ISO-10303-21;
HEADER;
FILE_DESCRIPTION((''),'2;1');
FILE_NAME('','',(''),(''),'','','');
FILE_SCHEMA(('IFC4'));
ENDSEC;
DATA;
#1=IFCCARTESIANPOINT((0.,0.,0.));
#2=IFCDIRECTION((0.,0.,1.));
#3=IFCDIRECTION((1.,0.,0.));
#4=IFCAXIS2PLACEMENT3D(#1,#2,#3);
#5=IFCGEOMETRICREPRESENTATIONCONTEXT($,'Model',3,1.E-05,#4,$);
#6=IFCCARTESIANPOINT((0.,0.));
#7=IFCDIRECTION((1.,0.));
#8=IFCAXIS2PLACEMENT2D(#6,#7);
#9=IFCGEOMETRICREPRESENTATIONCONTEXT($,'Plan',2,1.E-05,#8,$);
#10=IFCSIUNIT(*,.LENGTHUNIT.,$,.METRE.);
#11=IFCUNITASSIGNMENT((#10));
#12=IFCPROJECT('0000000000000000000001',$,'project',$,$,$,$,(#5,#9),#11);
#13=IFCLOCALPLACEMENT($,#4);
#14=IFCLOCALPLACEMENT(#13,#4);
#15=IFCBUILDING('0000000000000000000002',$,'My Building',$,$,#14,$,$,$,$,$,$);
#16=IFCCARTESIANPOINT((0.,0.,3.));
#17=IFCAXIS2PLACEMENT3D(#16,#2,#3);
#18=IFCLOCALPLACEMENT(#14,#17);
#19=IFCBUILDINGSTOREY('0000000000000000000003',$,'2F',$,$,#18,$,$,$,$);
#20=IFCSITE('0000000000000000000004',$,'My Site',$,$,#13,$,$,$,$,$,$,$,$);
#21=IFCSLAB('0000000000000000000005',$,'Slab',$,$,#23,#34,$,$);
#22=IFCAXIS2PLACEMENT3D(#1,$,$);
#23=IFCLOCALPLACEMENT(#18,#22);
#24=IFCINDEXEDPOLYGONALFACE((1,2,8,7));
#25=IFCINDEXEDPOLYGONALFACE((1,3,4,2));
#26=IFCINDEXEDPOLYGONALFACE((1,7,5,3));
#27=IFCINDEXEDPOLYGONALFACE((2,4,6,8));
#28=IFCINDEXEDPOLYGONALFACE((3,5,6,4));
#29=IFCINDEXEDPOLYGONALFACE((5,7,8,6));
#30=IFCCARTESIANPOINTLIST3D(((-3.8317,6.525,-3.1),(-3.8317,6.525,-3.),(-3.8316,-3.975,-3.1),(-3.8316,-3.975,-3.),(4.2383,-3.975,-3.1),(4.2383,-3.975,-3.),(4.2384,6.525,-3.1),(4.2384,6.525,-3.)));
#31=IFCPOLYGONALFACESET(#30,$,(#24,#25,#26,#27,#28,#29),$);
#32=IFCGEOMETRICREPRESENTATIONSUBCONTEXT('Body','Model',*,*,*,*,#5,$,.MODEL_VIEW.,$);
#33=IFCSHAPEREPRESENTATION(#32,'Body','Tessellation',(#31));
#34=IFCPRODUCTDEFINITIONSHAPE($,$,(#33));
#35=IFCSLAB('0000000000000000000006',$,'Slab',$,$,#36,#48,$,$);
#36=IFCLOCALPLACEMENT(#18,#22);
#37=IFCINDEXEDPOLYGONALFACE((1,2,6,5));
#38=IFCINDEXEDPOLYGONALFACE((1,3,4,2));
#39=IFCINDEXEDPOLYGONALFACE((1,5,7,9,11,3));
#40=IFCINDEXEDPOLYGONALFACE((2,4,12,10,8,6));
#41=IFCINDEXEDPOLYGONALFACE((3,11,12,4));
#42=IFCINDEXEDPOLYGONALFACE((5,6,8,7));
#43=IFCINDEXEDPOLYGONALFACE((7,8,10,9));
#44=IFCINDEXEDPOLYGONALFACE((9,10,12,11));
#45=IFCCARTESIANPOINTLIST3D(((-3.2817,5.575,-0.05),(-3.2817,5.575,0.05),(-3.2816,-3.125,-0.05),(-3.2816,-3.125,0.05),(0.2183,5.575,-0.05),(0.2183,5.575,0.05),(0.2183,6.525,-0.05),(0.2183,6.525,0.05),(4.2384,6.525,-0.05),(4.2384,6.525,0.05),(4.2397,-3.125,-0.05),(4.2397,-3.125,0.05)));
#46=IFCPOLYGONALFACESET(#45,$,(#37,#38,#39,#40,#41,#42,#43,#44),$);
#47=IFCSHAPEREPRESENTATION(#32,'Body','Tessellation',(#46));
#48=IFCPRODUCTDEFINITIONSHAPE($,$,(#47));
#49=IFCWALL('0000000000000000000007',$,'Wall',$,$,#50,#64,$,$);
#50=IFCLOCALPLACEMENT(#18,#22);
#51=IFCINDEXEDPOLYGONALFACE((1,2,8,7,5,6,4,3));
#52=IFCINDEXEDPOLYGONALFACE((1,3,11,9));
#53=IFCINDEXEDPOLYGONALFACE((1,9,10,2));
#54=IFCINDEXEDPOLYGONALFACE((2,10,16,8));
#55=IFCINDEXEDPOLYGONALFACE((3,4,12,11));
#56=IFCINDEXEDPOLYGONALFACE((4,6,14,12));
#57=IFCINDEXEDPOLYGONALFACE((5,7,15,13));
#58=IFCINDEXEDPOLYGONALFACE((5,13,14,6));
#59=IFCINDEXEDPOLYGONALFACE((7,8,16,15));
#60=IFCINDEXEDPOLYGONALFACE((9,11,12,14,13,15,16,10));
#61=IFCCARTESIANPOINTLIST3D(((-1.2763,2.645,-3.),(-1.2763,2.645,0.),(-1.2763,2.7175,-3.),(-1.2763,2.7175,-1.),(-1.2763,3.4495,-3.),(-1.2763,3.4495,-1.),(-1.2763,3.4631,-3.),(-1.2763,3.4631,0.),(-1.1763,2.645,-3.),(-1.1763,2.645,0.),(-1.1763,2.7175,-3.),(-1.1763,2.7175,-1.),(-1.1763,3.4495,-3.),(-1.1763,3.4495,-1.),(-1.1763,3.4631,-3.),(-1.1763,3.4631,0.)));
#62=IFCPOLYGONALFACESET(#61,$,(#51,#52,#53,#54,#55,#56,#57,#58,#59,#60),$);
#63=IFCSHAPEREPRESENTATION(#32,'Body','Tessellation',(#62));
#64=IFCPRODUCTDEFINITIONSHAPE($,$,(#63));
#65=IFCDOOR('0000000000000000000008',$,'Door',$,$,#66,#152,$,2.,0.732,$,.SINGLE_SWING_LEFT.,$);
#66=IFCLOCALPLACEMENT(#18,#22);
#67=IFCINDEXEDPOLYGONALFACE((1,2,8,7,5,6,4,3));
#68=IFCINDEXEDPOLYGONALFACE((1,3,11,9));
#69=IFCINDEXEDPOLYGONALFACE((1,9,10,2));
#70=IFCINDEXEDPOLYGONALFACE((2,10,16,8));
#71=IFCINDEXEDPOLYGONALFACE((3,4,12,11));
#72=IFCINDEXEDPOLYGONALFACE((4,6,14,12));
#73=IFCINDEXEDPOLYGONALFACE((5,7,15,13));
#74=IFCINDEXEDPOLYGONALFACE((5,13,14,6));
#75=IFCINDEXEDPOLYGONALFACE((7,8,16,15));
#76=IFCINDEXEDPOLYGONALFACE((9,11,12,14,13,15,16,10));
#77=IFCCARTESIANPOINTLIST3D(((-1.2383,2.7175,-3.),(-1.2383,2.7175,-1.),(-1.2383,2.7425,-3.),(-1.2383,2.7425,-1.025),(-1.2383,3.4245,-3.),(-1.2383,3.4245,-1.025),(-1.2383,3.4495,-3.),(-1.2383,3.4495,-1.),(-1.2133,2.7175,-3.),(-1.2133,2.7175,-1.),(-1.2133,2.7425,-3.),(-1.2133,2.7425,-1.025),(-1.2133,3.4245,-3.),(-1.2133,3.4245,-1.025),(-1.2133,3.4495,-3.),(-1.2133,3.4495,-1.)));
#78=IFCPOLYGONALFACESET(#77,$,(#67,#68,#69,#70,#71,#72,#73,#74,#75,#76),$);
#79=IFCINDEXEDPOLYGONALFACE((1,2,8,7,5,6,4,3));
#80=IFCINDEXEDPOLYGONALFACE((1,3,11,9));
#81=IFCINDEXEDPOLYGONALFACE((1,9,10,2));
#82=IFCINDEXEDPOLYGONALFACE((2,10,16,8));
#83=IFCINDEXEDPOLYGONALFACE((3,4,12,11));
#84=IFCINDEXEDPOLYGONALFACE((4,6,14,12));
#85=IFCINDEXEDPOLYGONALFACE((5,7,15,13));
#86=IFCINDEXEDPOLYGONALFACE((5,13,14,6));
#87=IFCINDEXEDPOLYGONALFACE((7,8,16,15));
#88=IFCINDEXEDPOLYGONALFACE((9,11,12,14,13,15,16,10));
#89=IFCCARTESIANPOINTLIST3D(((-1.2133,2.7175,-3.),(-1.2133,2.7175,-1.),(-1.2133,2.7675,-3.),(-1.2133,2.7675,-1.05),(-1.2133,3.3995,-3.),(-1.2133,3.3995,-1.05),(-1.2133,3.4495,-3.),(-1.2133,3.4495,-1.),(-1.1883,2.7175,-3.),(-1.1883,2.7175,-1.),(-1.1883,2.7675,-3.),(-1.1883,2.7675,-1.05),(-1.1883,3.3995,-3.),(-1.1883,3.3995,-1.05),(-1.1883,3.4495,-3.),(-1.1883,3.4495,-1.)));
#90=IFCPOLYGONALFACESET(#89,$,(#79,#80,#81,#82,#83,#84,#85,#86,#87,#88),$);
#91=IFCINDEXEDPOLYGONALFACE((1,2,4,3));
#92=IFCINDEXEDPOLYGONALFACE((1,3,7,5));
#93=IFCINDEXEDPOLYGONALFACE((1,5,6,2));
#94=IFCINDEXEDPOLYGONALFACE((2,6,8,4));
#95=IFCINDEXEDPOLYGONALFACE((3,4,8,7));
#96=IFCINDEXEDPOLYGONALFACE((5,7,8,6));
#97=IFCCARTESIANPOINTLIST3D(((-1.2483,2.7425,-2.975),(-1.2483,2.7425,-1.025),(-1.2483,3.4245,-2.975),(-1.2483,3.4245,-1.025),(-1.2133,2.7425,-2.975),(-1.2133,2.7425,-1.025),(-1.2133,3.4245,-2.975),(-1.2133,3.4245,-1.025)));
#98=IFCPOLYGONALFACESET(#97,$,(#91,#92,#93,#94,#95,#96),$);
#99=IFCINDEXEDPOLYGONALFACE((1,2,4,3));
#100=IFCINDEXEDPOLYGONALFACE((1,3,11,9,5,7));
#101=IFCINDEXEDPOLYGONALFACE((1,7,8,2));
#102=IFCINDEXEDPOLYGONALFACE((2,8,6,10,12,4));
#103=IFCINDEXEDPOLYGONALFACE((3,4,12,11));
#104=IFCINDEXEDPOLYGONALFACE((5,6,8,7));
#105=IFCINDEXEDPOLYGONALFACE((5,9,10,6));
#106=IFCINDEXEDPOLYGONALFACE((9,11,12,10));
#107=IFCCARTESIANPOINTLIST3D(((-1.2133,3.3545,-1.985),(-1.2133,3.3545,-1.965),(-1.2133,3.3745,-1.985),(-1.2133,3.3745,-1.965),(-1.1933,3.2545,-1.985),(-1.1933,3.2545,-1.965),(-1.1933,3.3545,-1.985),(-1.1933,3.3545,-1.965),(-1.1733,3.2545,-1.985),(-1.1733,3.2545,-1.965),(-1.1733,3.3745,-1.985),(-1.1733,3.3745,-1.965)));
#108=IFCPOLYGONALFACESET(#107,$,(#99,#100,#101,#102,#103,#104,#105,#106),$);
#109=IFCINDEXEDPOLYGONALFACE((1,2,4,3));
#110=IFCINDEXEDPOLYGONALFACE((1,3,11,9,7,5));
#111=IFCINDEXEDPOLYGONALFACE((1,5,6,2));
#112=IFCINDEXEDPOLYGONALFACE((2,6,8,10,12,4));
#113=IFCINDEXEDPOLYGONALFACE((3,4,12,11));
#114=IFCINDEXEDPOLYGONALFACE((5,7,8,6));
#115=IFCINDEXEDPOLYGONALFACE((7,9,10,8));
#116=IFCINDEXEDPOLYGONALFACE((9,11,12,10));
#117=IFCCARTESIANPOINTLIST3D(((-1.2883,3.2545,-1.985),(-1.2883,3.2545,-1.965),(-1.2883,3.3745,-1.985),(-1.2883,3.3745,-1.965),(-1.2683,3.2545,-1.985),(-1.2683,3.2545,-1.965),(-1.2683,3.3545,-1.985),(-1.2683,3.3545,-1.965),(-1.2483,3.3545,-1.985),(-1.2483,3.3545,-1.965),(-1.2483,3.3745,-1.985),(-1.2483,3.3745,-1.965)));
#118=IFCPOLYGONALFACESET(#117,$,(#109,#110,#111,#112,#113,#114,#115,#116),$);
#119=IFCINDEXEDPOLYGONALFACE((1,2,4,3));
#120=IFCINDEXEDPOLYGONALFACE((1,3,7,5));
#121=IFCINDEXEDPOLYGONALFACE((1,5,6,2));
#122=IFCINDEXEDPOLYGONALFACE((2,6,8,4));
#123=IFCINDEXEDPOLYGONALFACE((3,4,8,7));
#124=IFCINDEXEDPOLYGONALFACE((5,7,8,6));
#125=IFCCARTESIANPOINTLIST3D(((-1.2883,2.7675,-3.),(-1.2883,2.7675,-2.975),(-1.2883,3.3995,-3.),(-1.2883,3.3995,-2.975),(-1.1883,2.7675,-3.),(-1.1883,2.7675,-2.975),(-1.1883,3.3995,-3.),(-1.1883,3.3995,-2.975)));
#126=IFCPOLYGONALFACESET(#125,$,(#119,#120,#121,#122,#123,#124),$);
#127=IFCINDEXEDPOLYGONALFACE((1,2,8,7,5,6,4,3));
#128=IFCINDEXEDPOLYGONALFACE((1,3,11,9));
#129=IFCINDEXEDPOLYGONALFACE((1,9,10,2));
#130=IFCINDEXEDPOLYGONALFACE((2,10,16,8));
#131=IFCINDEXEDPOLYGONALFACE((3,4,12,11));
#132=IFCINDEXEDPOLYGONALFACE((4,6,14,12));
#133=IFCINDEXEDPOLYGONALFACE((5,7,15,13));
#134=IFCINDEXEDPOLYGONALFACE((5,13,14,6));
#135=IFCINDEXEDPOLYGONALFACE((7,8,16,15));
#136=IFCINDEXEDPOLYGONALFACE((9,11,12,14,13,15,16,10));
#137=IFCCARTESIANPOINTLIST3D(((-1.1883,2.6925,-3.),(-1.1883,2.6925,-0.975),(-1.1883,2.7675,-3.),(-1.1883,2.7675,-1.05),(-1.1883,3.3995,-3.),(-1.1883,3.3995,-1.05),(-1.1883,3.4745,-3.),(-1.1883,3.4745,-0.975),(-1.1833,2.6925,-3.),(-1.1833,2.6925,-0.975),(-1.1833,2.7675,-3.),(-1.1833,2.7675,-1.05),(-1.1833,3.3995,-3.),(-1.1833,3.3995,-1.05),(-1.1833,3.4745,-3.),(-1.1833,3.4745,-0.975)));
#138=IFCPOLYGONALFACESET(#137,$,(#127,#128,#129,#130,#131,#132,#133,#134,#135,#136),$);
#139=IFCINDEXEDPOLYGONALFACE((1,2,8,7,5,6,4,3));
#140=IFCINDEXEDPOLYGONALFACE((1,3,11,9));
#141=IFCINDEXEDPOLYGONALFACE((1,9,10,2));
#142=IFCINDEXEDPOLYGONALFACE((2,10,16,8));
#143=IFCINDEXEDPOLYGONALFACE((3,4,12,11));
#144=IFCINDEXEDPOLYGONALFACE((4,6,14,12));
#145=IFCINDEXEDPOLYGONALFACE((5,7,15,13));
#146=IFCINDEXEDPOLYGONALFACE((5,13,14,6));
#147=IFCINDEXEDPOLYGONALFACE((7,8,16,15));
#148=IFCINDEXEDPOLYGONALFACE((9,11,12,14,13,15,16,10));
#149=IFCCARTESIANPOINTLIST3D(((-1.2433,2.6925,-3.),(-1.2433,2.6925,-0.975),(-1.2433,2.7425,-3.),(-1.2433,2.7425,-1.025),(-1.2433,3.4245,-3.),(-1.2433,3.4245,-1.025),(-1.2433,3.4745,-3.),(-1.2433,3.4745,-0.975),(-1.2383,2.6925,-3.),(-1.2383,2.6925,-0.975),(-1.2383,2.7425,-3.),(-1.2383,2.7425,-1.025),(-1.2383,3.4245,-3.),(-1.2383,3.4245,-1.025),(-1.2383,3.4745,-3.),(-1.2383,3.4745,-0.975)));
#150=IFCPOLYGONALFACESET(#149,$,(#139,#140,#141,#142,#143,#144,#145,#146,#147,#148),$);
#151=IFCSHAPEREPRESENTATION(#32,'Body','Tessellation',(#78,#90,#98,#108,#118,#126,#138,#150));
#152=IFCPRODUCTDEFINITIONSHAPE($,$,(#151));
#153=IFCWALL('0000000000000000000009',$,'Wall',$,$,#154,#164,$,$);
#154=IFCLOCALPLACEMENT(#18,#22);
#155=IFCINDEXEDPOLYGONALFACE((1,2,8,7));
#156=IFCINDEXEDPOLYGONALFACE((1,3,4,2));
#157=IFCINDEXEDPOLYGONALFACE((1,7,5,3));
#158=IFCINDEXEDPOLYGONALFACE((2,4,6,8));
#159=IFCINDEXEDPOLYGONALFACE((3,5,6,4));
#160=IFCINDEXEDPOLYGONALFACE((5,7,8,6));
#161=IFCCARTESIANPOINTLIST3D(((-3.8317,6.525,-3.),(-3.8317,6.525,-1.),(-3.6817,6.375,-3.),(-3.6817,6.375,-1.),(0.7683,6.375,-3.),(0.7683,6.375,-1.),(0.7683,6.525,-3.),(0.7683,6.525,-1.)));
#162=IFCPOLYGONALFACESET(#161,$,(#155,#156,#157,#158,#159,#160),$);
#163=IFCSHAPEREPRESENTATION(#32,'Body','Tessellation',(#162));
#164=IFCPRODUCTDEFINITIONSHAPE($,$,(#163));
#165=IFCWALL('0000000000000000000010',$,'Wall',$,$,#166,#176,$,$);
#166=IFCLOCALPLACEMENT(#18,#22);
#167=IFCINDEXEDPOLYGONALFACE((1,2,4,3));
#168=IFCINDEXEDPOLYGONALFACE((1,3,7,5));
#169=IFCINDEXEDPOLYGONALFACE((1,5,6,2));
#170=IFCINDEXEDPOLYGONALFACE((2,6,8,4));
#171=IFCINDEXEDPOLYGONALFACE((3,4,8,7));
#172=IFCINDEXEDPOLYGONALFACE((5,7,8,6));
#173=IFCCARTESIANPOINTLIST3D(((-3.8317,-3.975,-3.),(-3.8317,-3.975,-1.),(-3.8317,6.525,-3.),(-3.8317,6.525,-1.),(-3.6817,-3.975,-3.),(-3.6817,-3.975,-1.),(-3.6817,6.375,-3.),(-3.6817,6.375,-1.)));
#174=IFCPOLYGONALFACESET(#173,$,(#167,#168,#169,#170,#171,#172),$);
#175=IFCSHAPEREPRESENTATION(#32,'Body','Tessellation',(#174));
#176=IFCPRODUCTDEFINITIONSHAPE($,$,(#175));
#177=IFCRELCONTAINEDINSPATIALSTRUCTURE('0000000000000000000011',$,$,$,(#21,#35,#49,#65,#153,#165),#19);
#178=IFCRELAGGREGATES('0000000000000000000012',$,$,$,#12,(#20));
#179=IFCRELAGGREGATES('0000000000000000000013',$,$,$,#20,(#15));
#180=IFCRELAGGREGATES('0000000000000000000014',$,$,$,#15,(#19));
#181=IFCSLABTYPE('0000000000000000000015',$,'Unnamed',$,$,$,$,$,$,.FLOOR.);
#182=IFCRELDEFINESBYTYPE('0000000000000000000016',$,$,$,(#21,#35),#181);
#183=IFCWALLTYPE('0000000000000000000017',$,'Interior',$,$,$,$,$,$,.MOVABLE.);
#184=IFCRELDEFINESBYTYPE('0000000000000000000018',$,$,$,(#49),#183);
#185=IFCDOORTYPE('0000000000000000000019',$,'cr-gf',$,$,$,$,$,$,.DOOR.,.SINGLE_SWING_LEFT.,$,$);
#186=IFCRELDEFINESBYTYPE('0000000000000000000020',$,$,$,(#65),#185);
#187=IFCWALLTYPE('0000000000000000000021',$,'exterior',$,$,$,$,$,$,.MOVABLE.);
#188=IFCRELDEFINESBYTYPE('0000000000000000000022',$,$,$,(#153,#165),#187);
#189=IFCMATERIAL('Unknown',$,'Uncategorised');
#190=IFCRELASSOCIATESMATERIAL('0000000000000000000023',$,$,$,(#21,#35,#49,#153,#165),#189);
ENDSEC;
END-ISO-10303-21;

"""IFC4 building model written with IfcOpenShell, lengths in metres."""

from ifc_helpers import new_model, entity, si_unit, frame, origin_with_axes, origin_2d_with_axis, place, context, subcontext, project, spatial, line, indexed_curve, outline, extrude, shape, source, transform, mapped, material, type_object, type_shapes, element, fill, save


model = new_model("IFC4")

# Units and contexts
model_context = context("Model", 3, precision=1e-05, world=origin_with_axes())
plan_context = context("Plan", 2, precision=1e-05, world=origin_2d_with_axis())
body_context_1 = subcontext(model_context, "Body", "Model", "MODEL_VIEW")
body_context_2 = subcontext(plan_context, "Body", "Plan", "PLAN_VIEW")
ifc_project = project(units=[si_unit("LENGTHUNIT", "METRE")], contexts=[model_context, plan_context])

# Site, building, storey
site_placement = place(None, origin_with_axes())
site = spatial("IfcSite", under=ifc_project, at=site_placement, Name="My Site")
building_placement = place(site_placement, origin_with_axes())
building = spatial("IfcBuilding", under=site, at=building_placement, Name="My Building")
storey_placement = place(building_placement, frame((0.0, 0.0, 3.0), z_axis=(0.0, 0.0, 1.0), x_axis=(1.0, 0.0, 0.0)))
storey = spatial("IfcBuildingStorey", under=building, at=storey_placement, Name="2F")

# Slabs
ifc_material = material(Name="Unknown", Category="Uncategorised")
slab_type = type_object("IfcSlabType", Name="Unnamed", PredefinedType="FLOOR")
for number, where, z_axis, x_axis, name in (
    (1, (4.2384, 6.525, -3.0), (0.0, 0.0, 1.0), (1.0, 0.0, 0.0), "Slab"),
):
    element("IfcSlab", number, at=place(storey_placement, frame(where, z_axis=z_axis, x_axis=x_axis)), inside=storey, type_object=slab_type, material=ifc_material, Name=name, context=body_context_1, shape_type="SweptSolid", body=[
        extrude(outline(indexed_curve([(0.0, 0.0), (-8.07, 0.0), (-8.07, -10.5), (0.0, -10.5), (0.0, 0.0)])), frame((0.0, 0.0, -0.1), z_axis=(0.0, 0.0, 1.0), x_axis=(1.0, 0.0, 0.0)), (0.0, 0.0, 1.0), 0.1),
    ])
slab_placement = place(storey_placement, frame((4.2384, 6.525, 0.05), z_axis=(0.0, 0.0, 1.0), x_axis=(1.0, 0.0, 0.0)))
element("IfcSlab", 2, at=slab_placement, inside=storey, type_object=slab_type, material=ifc_material, Name="Slab", context=body_context_1, shape_type="SweptSolid", body=[
    extrude(outline(indexed_curve([(0.0, 0.0), (-4.02, 0.0), (-4.02, -0.95), (-7.52, -0.95), (-7.52, -9.65), (0.0014, -9.65), (0.0, 0.0)])), frame((0.0, 0.0, -0.1), z_axis=(0.0, 0.0, 1.0), x_axis=(1.0, 0.0, 0.0)), (0.0, 0.0, 1.0), 0.1),
])

# Wall, opening, door
wall_type_1 = type_object("IfcWallType", Name="Interior", PredefinedType="MOVABLE")
wall_1_placement = place(storey_placement, frame((-1.2763, 3.4631, -3.0), z_axis=(0.0, 0.0, 1.0), x_axis=(0.0, -1.0, 0.0)))
wall_1 = element("IfcWall", 3, at=wall_1_placement, inside=storey, type_object=wall_type_1, material=ifc_material, Name="Wall", context=body_context_1, shape_type="SweptSolid", body=[
    extrude(outline(indexed_curve([(0.0, 0.0), (0.0, 0.1), (0.8182, 0.1), (0.8182, 0.0)], segments=[line(1, 2, 3, 4, 1)])), origin_with_axes(), (0.0, 0.0, 1.0), 3.0),
])
shared_shape_1 = source(origin_with_axes(), body_context_1, "Body", "SweptSolid", [
    extrude(outline(indexed_curve([(0.0, 0.0), (0.732, 0.0), (0.732, 2.0), (0.0, 2.0)], segments=[line(1, 2, 3, 4, 1)])), frame((0.0, -0.6, 0.0), z_axis=(0.0, -1.0, 0.0), x_axis=(1.0, 0.0, 0.0)), (0.0, 0.0, -1.0), 1.2),
])
opening_1_placement = place(wall_1_placement, frame((0.7456, 0.088, 0.0), z_axis=(0.0, 0.0, 1.0), x_axis=(-1.0, 0.0, 0.0)))
opening_1 = element("IfcOpeningElement", 4, at=opening_1_placement, cuts=wall_1, PredefinedType="OPENING", context=body_context_1, shape_type="MappedRepresentation", body=[
    mapped(shared_shape_1, transform((0.0, 0.0, 0.0), x_axis=(1.0, 0.0, 0.0), y_axis=(0.0, 1.0, 0.0), z_axis=(0.0, 0.0, 1.0), scale=1.0)),
])
door_type_1 = type_object("IfcDoorType", Name="cr-gf", OperationType="SINGLE_SWING_LEFT", PredefinedType="DOOR")
shared_shape_2 = source(origin_with_axes(), body_context_1, "Body", "SweptSolid", [
    extrude(outline(indexed_curve([(0.0, 0.0), (0.0, 2.0), (0.732, 2.0), (0.732, 0.0), (0.707, 0.0), (0.707, 1.975), (0.025, 1.975), (0.025, 0.0)], segments=[line(1, 2, 3, 4, 5, 6, 7, 8, 1)])), frame((0.0, 0.025, 0.0), z_axis=(0.0, -1.0, 0.0), x_axis=(1.0, 0.0, 0.0)), (0.0, 0.0, -1.0), 0.025),
    extrude(outline(indexed_curve([(0.0, 0.0), (0.0, 2.0), (0.732, 2.0), (0.732, 0.0), (0.682, 0.0), (0.682, 1.95), (0.05, 1.95), (0.05, 0.0)], segments=[line(1, 2, 3, 4, 5, 6, 7, 8, 1)])), frame((0.0, 0.0, 0.0), z_axis=(0.0, -1.0, 0.0), x_axis=(1.0, 0.0, 0.0)), (0.0, 0.0, -1.0), 0.025),
    extrude(outline(indexed_curve([(0.0, 0.0), (0.682, 0.0), (0.682, 0.035), (0.0, 0.035)], segments=[line(1, 2, 3, 4, 1)])), frame((0.025, 0.025, 0.025), z_axis=(0.0, 0.0, 1.0), x_axis=(1.0, 0.0, 0.0)), (0.0, 0.0, 1.0), 1.95),
    extrude(outline(indexed_curve([(0.0, 0.0), (0.0, -0.04), (-0.12, -0.04), (-0.12, -0.02), (-0.02, -0.02), (-0.02, 0.0)], segments=[line(1, 2, 3, 4, 5, 6, 1)])), frame((0.657, 0.025, 1.015), z_axis=(0.0, 0.0, 1.0), x_axis=(1.0, 0.0, 0.0)), (0.0, 0.0, 1.0), 0.02),
    extrude(outline(indexed_curve([(0.0, 0.0), (0.0, 0.04), (-0.12, 0.04), (-0.12, 0.02), (-0.02, 0.02), (-0.02, 0.0)], segments=[line(1, 2, 3, 4, 5, 6, 1)])), frame((0.657, 0.06, 1.015), z_axis=(0.0, 0.0, 1.0), x_axis=(1.0, 0.0, 0.0)), (0.0, 0.0, 1.0), 0.02),
    extrude(outline(indexed_curve([(0.0, 0.0), (0.632, 0.0), (0.632, 0.1), (0.0, 0.1)], segments=[line(1, 2, 3, 4, 1)])), frame((0.05, 0.0, 0.0), z_axis=(0.0, 0.0, 1.0), x_axis=(1.0, 0.0, 0.0)), (0.0, 0.0, 1.0), 0.025),
    extrude(outline(indexed_curve([(0.0, 0.0), (0.0, 2.025), (0.782, 2.025), (0.782, 0.0), (0.707, 0.0), (0.707, 1.95), (0.075, 1.95), (0.075, 0.0)], segments=[line(1, 2, 3, 4, 5, 6, 7, 8, 1)])), frame((-0.025, -0.005, 0.0), z_axis=(0.0, -1.0, 0.0), x_axis=(1.0, 0.0, 0.0)), (0.0, 0.0, -1.0), 0.005),
    extrude(outline(indexed_curve([(0.0, 0.0), (0.0, 2.025), (0.782, 2.025), (0.782, 0.0), (0.732, 0.0), (0.732, 1.975), (0.05, 1.975), (0.05, 0.0)], segments=[line(1, 2, 3, 4, 5, 6, 7, 8, 1)])), frame((-0.025, 0.05, 0.0), z_axis=(0.0, -1.0, 0.0), x_axis=(1.0, 0.0, 0.0)), (0.0, 0.0, -1.0), 0.005),
])
shared_shape_3 = source(origin_with_axes(), body_context_2, "Body", "Curve2D", [
    entity("IfcIndexedPolyCurve", entity("IfcCartesianPointList2D", [[0.0, 0.0], [0.0, 0.05], [0.025, 0.05], [0.025, 0.025], [0.05, 0.025], [0.05, 0.0]]), [entity("IfcLineIndex", [1, 2, 3, 4, 5, 6, 1])]),
    entity("IfcIndexedPolyCurve", entity("IfcCartesianPointList2D", [[0.732, 0.0], [0.732, 0.05], [0.707, 0.05], [0.707, 0.025], [0.682, 0.025], [0.682, 0.0]]), [entity("IfcLineIndex", [1, 2, 3, 4, 5, 6, 1])]),
    entity("IfcTrimmedCurve", entity("IfcEllipse", entity("IfcAxis2Placement2D", entity("IfcCartesianPoint", [0.06, 0.05]), entity("IfcDirection", [1.0, 0.0])), 0.647, 0.682), [entity("IfcCartesianPoint", [0.707, 0.05])], [entity("IfcCartesianPoint", [0.06, 0.732])], True, "CARTESIAN"),
    entity("IfcIndexedPolyCurve", entity("IfcCartesianPointList2D", [[0.025, 0.05], [0.06, 0.05], [0.06, 0.732], [0.025, 0.732]]), [entity("IfcLineIndex", [1, 2, 3, 4, 1])]),
])
type_shapes(door_type_1, [shared_shape_2, shared_shape_3])
door_1_placement = place(opening_1_placement, frame((0.0, 0.0, 0.0), z_axis=(0.0, 0.0, 1.0), x_axis=(1.0, 0.0, 0.0)))
door_1 = element("IfcDoor", 5, at=door_1_placement, inside=storey, type_object=door_type_1, Name="Door", OperationType="SINGLE_SWING_LEFT", OverallHeight=2.0, OverallWidth=0.732, shapes=[
    shape(body_context_1, "Body", "MappedRepresentation", [mapped(shared_shape_2, transform((0.0, 0.0, 0.0), x_axis=(1.0, 0.0, 0.0), y_axis=(0.0, 1.0, 0.0), z_axis=(0.0, 0.0, 1.0), scale=1.0))]),
    shape(body_context_2, "Body", "MappedRepresentation", [mapped(shared_shape_3, transform((0.0, 0.0, 0.0), x_axis=(1.0, 0.0, 0.0), y_axis=(0.0, 1.0, 0.0), z_axis=(0.0, 0.0, 1.0), scale=1.0))]),
])
fill(opening_1, door_1)

# Walls
wall_type_2 = type_object("IfcWallType", Name="exterior", PredefinedType="MOVABLE")
wall_2_placement = place(storey_placement, frame((0.7683, 6.525, -3.0), z_axis=(0.0, 0.0, 1.0), x_axis=(-1.0, 0.0, 0.0)))
element("IfcWall", 6, at=wall_2_placement, inside=storey, type_object=wall_type_2, material=ifc_material, Name="Wall", context=body_context_1, shape_type="SweptSolid", body=[
    extrude(outline(indexed_curve([(0.0, 0.0), (0.0, 0.15), (4.45, 0.15), (4.6, 0.0)], segments=[line(1, 2, 3, 4, 1)])), origin_with_axes(), (0.0, 0.0, 1.0), 2.0),
])
wall_3_placement = place(storey_placement, frame((-3.8317, 6.525, -3.0), z_axis=(0.0, 0.0, 1.0), x_axis=(0.0, -1.0, 0.0)))
element("IfcWall", 7, at=wall_3_placement, inside=storey, type_object=wall_type_2, material=ifc_material, Name="Wall", context=body_context_1, shape_type="SweptSolid", body=[
    extrude(outline(indexed_curve([(0.0, 0.0), (0.15, 0.15), (10.5, 0.15), (10.5, 0.0)], segments=[line(1, 2, 3, 4, 1)])), origin_with_axes(), (0.0, 0.0, 1.0), 2.0),
])

save(model, "model.ifc")
